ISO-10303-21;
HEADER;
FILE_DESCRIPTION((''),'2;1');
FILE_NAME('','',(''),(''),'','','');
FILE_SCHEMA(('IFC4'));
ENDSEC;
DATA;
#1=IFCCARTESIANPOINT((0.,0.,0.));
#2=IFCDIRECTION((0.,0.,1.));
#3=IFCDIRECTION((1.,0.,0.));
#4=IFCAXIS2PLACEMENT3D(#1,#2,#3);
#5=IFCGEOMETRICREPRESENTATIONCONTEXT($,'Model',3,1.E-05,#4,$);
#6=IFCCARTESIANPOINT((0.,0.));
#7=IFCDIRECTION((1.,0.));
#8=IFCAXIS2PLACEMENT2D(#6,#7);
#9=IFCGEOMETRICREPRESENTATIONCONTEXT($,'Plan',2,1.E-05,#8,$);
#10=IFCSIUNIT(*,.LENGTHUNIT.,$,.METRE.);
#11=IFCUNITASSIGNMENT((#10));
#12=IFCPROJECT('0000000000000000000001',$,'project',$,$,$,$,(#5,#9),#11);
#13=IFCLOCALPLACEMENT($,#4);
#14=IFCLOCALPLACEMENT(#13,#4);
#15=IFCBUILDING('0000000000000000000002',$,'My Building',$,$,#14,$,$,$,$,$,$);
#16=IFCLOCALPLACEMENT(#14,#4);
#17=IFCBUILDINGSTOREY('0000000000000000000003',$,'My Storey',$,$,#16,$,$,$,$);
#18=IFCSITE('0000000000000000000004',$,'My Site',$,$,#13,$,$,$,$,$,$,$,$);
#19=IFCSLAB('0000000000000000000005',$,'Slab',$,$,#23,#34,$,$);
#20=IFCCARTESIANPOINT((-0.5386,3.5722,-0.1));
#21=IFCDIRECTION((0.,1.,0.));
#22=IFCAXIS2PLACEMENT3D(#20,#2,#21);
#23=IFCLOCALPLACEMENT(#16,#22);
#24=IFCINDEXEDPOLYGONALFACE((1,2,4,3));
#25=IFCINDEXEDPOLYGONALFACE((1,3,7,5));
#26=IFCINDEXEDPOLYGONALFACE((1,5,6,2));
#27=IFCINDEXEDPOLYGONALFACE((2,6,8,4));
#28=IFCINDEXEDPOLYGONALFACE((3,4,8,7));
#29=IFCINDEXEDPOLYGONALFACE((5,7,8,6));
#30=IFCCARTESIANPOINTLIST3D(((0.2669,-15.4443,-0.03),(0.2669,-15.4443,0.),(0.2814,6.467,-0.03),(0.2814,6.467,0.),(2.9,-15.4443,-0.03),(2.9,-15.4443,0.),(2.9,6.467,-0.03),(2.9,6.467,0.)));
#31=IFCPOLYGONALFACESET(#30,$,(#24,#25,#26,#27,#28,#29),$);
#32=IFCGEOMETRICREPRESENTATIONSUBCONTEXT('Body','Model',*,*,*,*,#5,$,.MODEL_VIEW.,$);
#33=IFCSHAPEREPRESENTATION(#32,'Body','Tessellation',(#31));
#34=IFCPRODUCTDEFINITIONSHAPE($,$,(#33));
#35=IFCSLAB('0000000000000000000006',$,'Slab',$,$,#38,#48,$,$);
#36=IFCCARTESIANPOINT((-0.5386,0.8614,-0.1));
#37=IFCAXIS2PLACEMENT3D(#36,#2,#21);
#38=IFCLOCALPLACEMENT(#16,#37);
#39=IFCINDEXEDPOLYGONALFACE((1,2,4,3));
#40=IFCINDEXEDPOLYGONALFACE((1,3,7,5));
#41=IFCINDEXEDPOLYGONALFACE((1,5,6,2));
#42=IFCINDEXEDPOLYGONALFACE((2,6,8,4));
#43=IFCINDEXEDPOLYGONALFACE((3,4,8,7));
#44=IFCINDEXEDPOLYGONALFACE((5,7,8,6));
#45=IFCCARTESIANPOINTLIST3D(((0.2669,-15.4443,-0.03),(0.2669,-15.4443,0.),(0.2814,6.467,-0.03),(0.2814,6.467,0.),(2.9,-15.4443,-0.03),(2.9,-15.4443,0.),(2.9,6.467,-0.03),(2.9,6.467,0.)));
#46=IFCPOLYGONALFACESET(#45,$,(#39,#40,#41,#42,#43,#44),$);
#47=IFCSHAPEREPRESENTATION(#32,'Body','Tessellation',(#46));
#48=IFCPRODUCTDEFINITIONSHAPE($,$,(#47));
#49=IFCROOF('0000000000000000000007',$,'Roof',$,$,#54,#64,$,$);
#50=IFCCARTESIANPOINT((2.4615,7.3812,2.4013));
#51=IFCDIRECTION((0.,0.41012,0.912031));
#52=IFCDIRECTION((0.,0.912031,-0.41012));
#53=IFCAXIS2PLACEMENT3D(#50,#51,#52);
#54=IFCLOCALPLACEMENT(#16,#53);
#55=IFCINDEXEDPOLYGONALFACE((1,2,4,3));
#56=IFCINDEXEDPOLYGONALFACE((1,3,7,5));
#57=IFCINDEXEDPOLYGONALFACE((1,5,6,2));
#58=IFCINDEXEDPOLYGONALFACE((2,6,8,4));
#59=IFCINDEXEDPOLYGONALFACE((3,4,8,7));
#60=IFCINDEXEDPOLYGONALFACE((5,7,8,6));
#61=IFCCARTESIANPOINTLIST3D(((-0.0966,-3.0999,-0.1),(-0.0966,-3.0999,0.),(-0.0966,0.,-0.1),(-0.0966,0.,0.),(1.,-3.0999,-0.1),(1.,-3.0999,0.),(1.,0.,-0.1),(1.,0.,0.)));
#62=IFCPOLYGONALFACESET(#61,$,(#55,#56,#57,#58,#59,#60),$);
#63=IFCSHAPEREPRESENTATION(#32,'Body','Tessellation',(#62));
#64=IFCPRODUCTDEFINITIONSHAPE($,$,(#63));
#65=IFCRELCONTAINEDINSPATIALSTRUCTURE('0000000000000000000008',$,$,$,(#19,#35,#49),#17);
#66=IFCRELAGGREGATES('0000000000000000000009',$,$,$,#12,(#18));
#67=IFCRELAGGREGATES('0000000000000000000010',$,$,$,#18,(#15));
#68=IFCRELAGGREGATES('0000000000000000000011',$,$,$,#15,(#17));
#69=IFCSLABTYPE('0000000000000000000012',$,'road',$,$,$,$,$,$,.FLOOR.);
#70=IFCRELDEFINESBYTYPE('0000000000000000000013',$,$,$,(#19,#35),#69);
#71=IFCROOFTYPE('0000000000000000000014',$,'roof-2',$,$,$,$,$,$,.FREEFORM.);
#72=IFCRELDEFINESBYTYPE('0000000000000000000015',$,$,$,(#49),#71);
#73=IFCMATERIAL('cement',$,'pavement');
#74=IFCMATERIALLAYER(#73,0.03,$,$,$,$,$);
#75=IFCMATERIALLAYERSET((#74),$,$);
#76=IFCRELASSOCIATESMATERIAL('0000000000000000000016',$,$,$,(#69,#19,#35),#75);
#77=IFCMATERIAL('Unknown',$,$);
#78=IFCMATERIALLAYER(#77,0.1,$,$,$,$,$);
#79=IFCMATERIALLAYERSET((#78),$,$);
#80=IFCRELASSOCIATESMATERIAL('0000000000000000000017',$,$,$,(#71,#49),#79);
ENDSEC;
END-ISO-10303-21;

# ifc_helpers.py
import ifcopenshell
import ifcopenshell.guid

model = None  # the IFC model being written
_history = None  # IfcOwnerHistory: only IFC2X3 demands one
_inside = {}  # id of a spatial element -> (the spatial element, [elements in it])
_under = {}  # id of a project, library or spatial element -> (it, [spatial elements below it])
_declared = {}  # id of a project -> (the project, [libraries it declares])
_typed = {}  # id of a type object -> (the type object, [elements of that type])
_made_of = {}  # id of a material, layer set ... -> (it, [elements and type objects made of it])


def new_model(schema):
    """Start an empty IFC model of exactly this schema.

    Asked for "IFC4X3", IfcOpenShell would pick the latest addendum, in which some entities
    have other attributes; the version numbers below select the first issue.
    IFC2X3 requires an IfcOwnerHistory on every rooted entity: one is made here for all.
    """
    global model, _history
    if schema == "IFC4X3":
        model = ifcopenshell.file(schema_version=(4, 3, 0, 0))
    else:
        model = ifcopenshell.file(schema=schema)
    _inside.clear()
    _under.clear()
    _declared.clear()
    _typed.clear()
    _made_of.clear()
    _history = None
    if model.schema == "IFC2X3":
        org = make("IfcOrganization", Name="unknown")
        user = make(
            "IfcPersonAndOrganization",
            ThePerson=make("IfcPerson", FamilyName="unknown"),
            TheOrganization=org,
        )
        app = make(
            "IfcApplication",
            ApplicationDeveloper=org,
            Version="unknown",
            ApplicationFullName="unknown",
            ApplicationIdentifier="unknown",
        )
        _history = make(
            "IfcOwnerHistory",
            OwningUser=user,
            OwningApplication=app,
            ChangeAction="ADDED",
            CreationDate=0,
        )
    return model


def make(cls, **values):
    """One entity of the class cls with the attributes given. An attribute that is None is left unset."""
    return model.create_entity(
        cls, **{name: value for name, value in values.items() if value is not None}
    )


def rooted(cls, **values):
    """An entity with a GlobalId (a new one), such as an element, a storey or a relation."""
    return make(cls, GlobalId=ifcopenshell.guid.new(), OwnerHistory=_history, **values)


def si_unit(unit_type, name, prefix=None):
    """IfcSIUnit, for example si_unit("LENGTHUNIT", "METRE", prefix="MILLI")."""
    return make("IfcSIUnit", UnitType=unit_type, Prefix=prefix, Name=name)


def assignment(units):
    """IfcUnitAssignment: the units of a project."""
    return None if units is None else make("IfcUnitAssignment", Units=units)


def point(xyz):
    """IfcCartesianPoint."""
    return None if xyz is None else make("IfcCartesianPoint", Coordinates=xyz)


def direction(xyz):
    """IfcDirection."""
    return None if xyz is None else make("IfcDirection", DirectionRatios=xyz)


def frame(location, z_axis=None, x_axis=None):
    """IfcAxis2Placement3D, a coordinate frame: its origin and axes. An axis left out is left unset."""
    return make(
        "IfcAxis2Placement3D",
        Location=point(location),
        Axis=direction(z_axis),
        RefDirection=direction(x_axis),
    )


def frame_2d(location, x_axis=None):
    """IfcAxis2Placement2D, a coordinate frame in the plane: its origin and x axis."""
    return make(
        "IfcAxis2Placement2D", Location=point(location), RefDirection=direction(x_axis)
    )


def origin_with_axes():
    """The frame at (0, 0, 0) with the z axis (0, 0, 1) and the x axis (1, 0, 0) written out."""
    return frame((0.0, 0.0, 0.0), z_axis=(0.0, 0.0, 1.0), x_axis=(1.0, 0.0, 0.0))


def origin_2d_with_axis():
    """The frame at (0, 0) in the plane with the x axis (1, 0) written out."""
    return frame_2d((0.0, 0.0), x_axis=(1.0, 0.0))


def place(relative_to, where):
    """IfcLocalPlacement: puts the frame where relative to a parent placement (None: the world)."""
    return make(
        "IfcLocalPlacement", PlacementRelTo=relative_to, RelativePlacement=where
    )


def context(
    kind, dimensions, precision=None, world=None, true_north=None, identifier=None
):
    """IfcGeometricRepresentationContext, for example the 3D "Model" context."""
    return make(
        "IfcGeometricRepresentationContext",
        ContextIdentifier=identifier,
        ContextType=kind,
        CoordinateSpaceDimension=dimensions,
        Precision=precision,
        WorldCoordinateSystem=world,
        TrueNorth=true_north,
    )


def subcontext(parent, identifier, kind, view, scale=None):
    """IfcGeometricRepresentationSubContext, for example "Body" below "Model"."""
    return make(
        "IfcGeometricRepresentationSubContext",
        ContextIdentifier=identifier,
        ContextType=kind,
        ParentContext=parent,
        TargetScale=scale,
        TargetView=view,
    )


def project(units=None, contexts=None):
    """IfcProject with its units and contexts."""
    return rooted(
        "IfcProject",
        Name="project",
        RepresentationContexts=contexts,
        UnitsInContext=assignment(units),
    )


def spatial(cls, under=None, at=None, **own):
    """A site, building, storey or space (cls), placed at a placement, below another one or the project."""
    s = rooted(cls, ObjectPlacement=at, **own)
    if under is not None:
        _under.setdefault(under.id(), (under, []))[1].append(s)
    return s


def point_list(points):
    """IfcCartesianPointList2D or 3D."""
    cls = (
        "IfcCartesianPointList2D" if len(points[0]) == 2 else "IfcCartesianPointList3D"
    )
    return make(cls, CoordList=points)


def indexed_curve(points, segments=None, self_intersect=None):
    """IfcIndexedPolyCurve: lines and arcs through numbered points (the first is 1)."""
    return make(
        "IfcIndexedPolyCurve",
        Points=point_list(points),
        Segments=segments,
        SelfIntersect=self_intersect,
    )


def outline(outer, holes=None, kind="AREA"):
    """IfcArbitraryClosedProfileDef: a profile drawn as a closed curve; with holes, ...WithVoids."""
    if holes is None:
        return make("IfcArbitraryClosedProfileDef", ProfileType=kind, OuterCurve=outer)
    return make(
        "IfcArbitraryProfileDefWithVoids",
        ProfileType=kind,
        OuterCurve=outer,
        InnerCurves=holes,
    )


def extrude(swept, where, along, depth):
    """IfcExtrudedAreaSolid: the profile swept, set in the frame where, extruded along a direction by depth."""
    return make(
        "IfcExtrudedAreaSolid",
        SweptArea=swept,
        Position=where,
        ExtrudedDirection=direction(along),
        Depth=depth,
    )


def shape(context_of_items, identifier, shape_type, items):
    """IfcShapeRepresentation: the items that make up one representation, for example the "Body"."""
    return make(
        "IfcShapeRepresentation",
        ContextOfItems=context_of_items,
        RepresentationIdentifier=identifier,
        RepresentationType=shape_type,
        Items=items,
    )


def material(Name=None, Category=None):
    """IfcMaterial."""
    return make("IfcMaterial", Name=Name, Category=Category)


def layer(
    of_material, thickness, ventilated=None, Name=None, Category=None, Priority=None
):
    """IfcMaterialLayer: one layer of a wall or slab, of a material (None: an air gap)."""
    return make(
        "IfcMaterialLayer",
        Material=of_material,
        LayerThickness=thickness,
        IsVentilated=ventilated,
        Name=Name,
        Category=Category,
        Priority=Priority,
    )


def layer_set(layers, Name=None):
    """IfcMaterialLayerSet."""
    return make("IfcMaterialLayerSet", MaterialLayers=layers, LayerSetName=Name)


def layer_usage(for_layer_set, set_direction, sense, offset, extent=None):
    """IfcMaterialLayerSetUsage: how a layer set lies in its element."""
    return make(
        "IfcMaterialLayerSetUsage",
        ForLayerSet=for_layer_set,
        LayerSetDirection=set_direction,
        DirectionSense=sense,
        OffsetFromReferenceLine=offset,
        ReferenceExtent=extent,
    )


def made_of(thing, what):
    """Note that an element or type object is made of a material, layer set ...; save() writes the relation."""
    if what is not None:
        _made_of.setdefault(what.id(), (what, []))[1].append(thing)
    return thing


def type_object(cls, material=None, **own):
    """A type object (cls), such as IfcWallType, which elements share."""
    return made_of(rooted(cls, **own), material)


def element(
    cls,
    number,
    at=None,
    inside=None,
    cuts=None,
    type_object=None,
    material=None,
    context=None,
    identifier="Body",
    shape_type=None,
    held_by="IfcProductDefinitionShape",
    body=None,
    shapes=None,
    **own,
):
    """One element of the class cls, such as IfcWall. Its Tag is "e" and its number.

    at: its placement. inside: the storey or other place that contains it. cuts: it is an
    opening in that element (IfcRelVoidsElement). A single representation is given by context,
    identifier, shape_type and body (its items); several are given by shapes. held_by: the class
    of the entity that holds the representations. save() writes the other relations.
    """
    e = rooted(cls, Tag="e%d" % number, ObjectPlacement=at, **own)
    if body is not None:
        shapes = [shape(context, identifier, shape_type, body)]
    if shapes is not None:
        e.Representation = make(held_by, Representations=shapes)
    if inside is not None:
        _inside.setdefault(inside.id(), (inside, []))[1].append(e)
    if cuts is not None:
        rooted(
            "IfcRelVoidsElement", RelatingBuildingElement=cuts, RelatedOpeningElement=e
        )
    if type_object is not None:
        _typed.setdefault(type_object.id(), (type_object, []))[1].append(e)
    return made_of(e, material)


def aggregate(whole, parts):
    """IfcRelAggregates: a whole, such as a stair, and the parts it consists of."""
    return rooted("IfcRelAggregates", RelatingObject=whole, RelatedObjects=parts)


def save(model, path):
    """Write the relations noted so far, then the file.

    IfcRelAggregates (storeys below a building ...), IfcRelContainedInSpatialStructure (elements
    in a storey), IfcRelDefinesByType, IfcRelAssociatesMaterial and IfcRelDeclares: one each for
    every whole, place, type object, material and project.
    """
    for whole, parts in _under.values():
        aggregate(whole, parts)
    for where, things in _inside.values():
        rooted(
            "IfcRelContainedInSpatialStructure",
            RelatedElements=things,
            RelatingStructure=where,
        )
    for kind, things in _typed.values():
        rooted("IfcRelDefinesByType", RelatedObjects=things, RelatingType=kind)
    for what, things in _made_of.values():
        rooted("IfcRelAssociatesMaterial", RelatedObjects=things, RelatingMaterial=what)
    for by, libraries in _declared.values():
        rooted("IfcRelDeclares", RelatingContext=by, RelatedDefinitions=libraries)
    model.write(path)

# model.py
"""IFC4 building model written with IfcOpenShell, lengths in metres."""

from ifc_helpers import new_model, si_unit, frame, origin_with_axes, origin_2d_with_axis, place, context, subcontext, project, spatial, indexed_curve, outline, extrude, material, layer, layer_set, layer_usage, type_object, element, save


model = new_model("IFC4")

# Units and contexts
model_context = context("Model", 3, precision=1e-05, world=origin_with_axes())
plan_context = context("Plan", 2, precision=1e-05, world=origin_2d_with_axis())
body_context = subcontext(model_context, "Body", "Model", "MODEL_VIEW")
ifc_project = project(units=[si_unit("LENGTHUNIT", "METRE")], contexts=[model_context, plan_context])

# Site, building, storey
site_placement = place(None, origin_with_axes())
site = spatial("IfcSite", under=ifc_project, at=site_placement, Name="My Site")
building_placement = place(site_placement, origin_with_axes())
building = spatial("IfcBuilding", under=site, at=building_placement, Name="My Building")
storey_placement = place(building_placement, origin_with_axes())
storey = spatial("IfcBuildingStorey", under=building, at=storey_placement, Name="My Storey")

# Shared definitions
ifc_material_1 = material(Name="Unknown")

# Slabs
ifc_material_2 = material(Name="cement", Category="pavement")
ifc_layer_1 = layer(ifc_material_2, 0.03)
ifc_layer_set_1 = layer_set([ifc_layer_1])
ifc_layer_usage_1 = layer_usage(ifc_layer_set_1, "AXIS3", "POSITIVE", -0.03)
slab_type_1 = type_object("IfcSlabType", Name="road", PredefinedType="FLOOR", material=ifc_layer_set_1)
slab_1_placement = place(storey_placement, frame((-0.5386, 3.5722, -0.1), z_axis=(0.0, 0.0, 1.0), x_axis=(0.0, 1.0, 0.0)))
element("IfcSlab", 1, at=slab_1_placement, inside=storey, type_object=slab_type_1, material=ifc_layer_usage_1, Name="Slab", context=body_context, shape_type="SweptSolid", body=[
    extrude(outline(indexed_curve([(0.2669, -15.4443), (2.9, -15.4443), (2.9, 6.467), (0.2814, 6.467), (0.2669, -15.4443)])), frame((0.0, 0.0, -0.03), z_axis=(0.0, 0.0, 1.0), x_axis=(1.0, 0.0, 0.0)), (0.0, 0.0, 1.0), 0.03),
])
ifc_layer_usage_2 = layer_usage(ifc_layer_set_1, "AXIS3", "POSITIVE", -0.03)
slab_2_placement = place(storey_placement, frame((-0.5386, 0.8614, -0.1), z_axis=(0.0, 0.0, 1.0), x_axis=(0.0, 1.0, 0.0)))
element("IfcSlab", 2, at=slab_2_placement, inside=storey, type_object=slab_type_1, material=ifc_layer_usage_2, Name="Slab", context=body_context, shape_type="SweptSolid", body=[
    extrude(outline(indexed_curve([(0.2669, -15.4443), (2.9, -15.4443), (2.9, 6.467), (0.2814, 6.467), (0.2669, -15.4443)])), frame((0.0, 0.0, -0.03), z_axis=(0.0, 0.0, 1.0), x_axis=(1.0, 0.0, 0.0)), (0.0, 0.0, 1.0), 0.03),
])

# Roof
ifc_layer_2 = layer(ifc_material_1, 0.1)
ifc_layer_set_2 = layer_set([ifc_layer_2])
ifc_layer_usage_3 = layer_usage(ifc_layer_set_2, "AXIS3", "POSITIVE", -0.1)
roof_type_1 = type_object("IfcRoofType", Name="roof-2", PredefinedType="FREEFORM", material=ifc_layer_set_2)
roof_1_placement = place(storey_placement, frame((2.4615, 7.3812, 2.4013), z_axis=(0.0, 0.41012, 0.912031), x_axis=(0.0, 0.912031, -0.41012)))
element("IfcRoof", 3, at=roof_1_placement, inside=storey, type_object=roof_type_1, material=ifc_layer_usage_3, Name="Roof", context=body_context, shape_type="SweptSolid", body=[
    extrude(outline(indexed_curve([(-0.0966, 0.0), (-0.0966, -3.0999), (1.0, -3.0999), (1.0, 0.0), (-0.0966, 0.0)])), frame((0.0, 0.0, -0.1), z_axis=(0.0, 0.0, 1.0), x_axis=(1.0, 0.0, 0.0)), (0.0, 0.0, 1.0), 0.1),
])

save(model, "model.ifc")
